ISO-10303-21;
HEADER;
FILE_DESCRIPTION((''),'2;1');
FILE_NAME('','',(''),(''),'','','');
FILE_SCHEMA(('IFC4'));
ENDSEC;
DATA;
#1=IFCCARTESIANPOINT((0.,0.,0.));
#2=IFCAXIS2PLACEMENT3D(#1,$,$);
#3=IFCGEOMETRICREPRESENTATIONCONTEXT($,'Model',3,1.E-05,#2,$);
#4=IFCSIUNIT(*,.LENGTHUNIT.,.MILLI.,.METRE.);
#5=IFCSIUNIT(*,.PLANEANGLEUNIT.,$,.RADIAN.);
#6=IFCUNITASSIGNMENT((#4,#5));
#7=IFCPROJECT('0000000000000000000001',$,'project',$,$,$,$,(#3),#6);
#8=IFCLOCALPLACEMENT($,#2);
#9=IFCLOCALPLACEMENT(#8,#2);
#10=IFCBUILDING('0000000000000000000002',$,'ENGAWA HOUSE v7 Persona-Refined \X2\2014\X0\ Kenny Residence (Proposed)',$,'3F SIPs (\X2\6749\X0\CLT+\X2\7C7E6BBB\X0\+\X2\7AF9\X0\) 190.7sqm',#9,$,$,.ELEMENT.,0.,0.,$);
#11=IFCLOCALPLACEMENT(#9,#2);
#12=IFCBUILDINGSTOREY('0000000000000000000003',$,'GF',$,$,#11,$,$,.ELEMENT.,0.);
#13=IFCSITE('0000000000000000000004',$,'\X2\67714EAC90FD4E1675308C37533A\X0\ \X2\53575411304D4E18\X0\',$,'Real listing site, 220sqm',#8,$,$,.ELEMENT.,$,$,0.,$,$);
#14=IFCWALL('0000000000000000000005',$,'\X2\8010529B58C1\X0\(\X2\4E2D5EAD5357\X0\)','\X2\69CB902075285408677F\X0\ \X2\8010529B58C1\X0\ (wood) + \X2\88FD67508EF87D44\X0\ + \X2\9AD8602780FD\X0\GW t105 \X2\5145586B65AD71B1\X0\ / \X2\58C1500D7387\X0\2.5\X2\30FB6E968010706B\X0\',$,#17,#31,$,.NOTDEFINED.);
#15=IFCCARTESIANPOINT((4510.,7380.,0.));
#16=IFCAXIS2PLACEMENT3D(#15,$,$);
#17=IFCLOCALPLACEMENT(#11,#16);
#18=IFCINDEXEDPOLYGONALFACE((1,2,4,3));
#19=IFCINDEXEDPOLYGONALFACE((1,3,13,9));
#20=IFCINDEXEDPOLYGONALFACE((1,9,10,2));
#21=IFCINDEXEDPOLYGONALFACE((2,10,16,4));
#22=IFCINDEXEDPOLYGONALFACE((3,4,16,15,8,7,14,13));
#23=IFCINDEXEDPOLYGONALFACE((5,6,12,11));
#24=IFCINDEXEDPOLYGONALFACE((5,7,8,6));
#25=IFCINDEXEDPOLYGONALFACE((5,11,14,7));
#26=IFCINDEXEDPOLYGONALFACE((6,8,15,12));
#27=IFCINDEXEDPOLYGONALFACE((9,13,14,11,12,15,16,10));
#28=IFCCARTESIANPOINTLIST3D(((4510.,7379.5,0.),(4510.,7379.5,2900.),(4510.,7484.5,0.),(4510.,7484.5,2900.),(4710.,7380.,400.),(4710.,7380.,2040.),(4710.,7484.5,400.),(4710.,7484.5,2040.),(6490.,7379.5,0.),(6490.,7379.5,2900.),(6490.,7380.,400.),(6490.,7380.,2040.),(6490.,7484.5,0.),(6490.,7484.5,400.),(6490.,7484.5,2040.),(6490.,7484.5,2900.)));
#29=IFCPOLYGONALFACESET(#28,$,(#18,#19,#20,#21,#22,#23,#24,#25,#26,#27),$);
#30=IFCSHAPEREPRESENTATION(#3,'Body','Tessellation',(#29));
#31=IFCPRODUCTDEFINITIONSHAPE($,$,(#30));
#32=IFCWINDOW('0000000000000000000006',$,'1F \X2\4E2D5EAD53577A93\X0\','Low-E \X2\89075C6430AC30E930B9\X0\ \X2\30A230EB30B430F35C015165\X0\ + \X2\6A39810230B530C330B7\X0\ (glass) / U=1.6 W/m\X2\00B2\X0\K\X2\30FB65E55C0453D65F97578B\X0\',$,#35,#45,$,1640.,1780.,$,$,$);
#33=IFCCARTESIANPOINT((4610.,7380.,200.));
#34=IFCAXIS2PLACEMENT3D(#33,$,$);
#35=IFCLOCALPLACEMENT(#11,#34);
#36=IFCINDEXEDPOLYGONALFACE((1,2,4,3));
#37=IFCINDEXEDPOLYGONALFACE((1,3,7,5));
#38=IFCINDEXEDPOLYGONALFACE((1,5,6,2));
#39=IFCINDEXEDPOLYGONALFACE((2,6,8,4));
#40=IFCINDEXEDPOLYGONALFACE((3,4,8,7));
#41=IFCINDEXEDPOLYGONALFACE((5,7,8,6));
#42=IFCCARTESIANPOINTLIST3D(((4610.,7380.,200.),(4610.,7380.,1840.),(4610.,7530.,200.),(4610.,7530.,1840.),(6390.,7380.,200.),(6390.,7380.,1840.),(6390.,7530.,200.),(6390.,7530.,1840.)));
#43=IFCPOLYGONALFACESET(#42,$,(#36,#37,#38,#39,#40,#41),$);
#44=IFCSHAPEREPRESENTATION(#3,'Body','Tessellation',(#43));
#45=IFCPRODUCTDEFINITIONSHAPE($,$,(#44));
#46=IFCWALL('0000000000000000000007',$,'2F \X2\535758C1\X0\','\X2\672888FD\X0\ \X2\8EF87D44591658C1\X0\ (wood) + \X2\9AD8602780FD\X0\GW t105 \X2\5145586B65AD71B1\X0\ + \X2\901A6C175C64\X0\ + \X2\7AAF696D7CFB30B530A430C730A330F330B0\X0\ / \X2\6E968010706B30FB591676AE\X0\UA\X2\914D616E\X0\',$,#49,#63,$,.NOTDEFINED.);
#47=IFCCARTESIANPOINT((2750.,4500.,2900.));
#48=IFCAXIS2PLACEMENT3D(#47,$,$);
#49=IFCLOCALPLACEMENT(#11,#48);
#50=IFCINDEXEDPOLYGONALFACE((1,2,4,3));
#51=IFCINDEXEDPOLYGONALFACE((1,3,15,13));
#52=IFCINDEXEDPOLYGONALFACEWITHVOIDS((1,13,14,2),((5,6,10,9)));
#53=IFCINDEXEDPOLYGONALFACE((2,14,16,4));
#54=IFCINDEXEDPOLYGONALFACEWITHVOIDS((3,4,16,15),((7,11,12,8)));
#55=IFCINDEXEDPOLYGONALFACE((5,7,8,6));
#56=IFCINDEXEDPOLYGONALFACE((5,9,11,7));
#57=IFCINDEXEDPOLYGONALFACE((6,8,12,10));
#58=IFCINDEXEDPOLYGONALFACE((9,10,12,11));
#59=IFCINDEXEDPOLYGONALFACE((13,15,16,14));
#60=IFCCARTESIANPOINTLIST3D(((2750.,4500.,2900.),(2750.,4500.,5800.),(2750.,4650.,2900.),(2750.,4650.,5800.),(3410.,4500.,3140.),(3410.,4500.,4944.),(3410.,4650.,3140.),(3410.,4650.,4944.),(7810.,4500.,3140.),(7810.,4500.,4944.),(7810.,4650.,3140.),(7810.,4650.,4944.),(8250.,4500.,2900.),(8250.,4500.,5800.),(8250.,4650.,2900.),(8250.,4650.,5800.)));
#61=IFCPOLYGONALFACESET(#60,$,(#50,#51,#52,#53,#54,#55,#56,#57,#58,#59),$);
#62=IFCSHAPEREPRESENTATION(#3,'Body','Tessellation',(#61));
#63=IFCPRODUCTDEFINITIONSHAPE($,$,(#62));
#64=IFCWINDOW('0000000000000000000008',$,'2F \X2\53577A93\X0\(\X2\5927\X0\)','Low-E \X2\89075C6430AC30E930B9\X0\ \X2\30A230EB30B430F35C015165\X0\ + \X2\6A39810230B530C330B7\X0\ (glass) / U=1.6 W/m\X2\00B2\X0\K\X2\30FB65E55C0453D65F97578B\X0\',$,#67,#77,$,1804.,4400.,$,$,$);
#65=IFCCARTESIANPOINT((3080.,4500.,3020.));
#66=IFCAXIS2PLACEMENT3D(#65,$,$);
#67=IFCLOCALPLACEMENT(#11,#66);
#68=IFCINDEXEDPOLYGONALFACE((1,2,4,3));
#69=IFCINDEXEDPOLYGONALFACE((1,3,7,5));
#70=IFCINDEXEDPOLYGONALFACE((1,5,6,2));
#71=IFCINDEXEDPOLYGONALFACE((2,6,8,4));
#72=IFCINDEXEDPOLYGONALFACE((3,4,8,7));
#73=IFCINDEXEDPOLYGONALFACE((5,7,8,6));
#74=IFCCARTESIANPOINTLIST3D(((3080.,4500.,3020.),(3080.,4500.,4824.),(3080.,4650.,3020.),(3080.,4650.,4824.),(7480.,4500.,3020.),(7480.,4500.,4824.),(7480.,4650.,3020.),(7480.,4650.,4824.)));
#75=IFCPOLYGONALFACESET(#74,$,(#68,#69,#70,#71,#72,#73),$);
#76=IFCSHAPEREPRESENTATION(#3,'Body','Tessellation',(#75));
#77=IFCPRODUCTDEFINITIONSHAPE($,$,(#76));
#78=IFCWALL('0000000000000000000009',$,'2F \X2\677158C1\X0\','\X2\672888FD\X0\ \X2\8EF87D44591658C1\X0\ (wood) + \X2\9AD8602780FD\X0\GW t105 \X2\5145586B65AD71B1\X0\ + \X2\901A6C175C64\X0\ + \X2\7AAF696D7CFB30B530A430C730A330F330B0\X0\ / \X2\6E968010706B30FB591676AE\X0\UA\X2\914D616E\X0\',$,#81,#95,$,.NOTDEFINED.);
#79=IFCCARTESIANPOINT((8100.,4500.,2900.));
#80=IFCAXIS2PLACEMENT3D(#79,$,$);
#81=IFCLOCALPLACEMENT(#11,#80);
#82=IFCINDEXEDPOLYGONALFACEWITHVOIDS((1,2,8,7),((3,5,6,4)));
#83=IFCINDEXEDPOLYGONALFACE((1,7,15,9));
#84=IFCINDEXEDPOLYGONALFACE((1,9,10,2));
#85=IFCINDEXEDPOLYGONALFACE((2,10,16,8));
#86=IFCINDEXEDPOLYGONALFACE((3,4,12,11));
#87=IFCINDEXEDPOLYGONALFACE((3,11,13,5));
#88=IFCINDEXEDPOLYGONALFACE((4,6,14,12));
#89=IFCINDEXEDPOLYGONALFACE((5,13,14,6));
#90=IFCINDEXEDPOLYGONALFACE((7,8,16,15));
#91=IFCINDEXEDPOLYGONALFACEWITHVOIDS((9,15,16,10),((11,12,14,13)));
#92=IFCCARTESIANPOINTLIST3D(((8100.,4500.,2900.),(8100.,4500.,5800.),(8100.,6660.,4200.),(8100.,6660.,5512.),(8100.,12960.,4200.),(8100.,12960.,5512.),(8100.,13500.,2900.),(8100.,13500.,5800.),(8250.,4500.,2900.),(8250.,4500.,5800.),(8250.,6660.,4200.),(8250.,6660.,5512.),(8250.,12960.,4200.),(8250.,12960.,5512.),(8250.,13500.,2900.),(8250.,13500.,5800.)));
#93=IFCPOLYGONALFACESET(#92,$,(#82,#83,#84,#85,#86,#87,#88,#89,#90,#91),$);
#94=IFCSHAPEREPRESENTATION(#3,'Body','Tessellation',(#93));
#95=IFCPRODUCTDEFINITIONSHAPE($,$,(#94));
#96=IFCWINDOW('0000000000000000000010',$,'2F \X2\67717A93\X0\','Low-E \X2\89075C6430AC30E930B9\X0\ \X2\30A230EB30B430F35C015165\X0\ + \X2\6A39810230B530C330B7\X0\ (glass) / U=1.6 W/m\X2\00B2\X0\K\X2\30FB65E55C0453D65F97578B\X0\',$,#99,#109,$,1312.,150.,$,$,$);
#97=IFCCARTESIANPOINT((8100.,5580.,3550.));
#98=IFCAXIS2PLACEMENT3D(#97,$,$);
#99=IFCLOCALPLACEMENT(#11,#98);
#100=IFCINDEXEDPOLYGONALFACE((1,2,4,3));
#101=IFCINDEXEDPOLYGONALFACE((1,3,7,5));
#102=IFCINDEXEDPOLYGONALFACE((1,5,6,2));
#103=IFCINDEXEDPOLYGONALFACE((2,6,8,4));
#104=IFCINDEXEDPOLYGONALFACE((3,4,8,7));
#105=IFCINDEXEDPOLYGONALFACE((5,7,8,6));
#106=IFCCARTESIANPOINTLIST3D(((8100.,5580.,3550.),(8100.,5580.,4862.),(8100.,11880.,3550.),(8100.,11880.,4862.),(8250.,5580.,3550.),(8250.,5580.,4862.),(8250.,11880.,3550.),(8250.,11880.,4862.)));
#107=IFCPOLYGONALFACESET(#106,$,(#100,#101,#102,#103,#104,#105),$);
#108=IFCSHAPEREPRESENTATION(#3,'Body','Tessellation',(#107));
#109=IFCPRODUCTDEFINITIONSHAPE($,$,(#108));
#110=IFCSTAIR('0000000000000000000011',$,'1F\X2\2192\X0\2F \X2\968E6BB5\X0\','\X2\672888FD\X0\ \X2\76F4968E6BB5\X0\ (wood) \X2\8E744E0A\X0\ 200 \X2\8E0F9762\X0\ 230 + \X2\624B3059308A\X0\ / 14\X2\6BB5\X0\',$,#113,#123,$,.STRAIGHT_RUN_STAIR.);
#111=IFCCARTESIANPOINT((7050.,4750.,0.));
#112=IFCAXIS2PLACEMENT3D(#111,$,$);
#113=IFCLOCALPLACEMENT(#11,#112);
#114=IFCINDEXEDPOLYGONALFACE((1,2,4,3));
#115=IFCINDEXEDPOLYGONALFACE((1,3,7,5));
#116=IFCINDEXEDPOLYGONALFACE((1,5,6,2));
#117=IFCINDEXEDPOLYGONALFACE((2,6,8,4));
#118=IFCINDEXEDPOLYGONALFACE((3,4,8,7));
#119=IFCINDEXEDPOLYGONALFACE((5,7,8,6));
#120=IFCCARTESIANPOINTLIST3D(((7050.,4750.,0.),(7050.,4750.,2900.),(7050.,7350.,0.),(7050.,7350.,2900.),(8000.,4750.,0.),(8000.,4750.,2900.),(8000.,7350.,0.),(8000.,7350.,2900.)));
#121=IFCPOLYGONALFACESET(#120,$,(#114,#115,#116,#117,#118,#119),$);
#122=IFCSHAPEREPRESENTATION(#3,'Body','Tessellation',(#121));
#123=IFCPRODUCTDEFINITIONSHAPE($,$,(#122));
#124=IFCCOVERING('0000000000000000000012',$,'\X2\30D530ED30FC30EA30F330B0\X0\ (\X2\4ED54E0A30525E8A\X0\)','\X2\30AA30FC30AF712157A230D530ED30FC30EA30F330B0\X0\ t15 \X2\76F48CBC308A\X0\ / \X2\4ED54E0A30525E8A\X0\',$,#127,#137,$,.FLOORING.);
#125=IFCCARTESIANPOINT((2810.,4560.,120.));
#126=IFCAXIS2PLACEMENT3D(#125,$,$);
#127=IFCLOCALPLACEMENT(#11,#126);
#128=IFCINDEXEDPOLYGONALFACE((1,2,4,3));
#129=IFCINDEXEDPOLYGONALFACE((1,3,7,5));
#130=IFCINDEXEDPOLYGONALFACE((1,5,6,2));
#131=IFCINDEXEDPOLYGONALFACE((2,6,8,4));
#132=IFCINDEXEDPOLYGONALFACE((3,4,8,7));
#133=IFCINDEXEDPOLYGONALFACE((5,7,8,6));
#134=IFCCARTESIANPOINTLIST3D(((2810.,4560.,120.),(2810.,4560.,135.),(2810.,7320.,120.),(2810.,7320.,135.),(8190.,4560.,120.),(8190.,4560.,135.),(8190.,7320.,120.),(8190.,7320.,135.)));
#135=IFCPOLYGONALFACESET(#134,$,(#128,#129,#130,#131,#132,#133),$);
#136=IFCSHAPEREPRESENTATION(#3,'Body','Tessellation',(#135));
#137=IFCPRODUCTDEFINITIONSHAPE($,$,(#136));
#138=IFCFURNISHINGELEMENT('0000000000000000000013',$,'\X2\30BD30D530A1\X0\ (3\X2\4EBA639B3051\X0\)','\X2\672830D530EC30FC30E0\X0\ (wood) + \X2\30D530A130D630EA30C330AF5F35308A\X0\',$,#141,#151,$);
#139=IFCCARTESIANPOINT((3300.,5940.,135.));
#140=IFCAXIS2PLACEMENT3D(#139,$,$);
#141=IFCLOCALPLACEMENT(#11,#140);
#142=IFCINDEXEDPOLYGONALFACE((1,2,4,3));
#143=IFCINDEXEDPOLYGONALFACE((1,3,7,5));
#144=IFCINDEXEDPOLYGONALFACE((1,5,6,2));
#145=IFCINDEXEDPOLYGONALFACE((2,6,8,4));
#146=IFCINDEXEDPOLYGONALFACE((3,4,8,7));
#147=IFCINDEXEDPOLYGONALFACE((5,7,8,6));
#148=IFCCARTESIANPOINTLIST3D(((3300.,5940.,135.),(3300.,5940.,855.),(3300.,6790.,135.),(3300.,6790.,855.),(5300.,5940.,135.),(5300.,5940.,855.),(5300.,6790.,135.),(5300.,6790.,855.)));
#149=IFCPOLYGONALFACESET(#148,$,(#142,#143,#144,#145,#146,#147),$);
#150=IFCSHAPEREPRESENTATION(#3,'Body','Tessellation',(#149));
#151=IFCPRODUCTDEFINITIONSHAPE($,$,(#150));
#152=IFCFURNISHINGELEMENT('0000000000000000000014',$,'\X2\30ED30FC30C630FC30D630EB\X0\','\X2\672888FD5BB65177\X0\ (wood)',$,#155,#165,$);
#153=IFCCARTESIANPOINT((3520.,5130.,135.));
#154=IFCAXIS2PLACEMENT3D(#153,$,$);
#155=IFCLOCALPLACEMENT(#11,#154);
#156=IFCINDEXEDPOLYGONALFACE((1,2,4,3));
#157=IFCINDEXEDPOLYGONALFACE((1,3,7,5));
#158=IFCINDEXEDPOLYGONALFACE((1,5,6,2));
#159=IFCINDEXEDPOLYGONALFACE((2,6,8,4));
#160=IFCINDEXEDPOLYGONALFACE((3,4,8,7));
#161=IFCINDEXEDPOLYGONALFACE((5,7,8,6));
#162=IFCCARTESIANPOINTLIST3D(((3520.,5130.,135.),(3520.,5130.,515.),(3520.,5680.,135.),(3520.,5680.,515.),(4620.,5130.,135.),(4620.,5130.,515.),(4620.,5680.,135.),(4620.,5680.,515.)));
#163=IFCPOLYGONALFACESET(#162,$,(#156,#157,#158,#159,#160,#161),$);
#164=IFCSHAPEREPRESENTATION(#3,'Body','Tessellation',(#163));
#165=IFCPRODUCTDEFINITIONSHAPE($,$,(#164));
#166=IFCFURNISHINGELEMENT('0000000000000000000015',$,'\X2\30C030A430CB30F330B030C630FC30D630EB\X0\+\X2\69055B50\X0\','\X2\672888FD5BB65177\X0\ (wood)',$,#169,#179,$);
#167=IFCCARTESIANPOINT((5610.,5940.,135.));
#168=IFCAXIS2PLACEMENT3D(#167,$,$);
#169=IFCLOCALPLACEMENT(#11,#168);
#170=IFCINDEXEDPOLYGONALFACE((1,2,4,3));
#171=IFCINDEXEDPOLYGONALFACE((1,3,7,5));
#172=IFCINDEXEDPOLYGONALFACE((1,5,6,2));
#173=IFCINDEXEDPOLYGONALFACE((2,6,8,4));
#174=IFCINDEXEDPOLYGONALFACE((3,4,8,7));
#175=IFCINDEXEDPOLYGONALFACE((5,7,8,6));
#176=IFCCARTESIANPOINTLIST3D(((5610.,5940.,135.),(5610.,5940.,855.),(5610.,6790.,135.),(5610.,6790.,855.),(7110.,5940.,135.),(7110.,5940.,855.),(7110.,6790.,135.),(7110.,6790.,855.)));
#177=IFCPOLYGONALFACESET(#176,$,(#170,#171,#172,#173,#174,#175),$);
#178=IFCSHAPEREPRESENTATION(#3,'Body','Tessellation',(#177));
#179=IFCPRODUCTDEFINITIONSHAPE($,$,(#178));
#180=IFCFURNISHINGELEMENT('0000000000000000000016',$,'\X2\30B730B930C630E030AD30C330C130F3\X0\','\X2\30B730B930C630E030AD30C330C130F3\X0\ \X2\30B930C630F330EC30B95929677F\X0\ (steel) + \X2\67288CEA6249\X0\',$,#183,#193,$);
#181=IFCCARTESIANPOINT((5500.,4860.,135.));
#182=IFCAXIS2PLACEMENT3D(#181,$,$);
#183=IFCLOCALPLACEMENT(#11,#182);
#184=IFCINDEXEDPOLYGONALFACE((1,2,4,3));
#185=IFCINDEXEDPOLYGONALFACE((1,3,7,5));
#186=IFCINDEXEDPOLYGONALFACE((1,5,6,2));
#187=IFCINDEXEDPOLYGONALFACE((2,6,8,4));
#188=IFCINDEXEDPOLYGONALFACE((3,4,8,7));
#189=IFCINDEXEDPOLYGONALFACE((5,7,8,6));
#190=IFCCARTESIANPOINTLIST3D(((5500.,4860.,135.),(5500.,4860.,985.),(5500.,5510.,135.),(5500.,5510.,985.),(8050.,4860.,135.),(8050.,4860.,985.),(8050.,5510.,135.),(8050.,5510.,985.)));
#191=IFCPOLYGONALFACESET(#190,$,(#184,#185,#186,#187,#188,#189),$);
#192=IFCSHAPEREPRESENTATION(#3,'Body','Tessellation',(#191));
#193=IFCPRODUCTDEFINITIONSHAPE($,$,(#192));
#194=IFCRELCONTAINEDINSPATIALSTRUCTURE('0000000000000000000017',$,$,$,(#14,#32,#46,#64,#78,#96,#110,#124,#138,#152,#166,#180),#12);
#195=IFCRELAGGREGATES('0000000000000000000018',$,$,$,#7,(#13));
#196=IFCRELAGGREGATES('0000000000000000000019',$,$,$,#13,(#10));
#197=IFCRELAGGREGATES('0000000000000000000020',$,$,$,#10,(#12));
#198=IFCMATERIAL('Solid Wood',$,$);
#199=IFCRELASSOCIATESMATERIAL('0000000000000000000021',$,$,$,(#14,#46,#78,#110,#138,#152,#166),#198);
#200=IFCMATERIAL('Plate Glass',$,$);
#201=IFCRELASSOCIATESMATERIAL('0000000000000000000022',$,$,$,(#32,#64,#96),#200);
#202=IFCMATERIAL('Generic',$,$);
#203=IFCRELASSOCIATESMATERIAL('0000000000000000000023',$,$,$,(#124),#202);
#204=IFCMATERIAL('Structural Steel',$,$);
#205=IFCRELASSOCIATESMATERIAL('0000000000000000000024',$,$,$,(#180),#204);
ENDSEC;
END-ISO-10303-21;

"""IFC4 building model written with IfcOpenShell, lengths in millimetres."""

from ifc_helpers import new_model, si_unit, frame, frame_2d, origin, place, context, project, spatial, rectangle, extrude, material, element, fill, save


model = new_model("IFC4")

# Units and contexts
model_context = context("Model", 3, precision=1e-05, world=origin())
ifc_project = project(units=[si_unit("LENGTHUNIT", "METRE", prefix="MILLI"), si_unit("PLANEANGLEUNIT", "RADIAN")], contexts=[model_context])

# Site, building, storey
site_placement = place(None, origin())
site = spatial("IfcSite", under=ifc_project, at=site_placement, Name="東京都世田谷区 南向き丘", ObjectType="Real listing site, 220sqm", CompositionType="ELEMENT", RefElevation=0.0)
building_placement = place(site_placement, origin())
building = spatial("IfcBuilding", under=site, at=building_placement, Name="ENGAWA HOUSE v7 Persona-Refined — Kenny Residence (Proposed)", ObjectType="3F SIPs (杉CLT+籾殻+竹) 190.7sqm", CompositionType="ELEMENT", ElevationOfRefHeight=0.0, ElevationOfTerrain=0.0)
storey_placement = place(building_placement, origin())
storey = spatial("IfcBuildingStorey", under=building, at=storey_placement, Name="GF", CompositionType="ELEMENT", Elevation=0.0)

# Shared definitions
ifc_material_1 = material(Name="Solid Wood")
ifc_material_2 = material(Name="Generic")

# Shared definitions
ifc_material_3 = material(Name="Plate Glass")

# Wall, opening, window
wall_1_placement = place(storey_placement, frame((4510.0, 7380.0, 0.0)))
wall_1 = element("IfcWall", 1, at=wall_1_placement, inside=storey, material=ifc_material_1, Name="耐力壁(中庭南)", Description="構造用合板 耐力壁 (wood) + 製材軸組 + 高性能GW t105 充填断熱 / 壁倍率2.5・準耐火", PredefinedType="NOTDEFINED", context=model_context, shape_type="SweptSolid", body=[
    extrude(rectangle(XDim=1980.0, YDim=105.0, at=frame_2d((990.0, 52.0))), frame((4510.0, 7380.0, 0.0)), (0.0, 0.0, 1.0), 2900.0),
])
opening_1_placement = place(storey_placement, frame((4610.0, 7380.0, 200.0)))
opening_1 = element("IfcOpeningElement", 2, at=opening_1_placement, cuts=wall_1, PredefinedType="NOTDEFINED", context=model_context, shape_type="SweptSolid", body=[
    extrude(rectangle(XDim=1780.0, YDim=150.0, at=frame_2d((890.0, 75.0))), frame((4610.0, 7380.0, 200.0)), (0.0, 0.0, 1.0), 1640.0),
])
window_1_placement = place(storey_placement, frame((4610.0, 7380.0, 200.0)))
window_1 = element("IfcWindow", 3, at=window_1_placement, inside=storey, material=ifc_material_3, Name="1F 中庭南窓", Description="Low-E 複層ガラス アルゴン封入 + 樹脂サッシ (glass) / U=1.6 W/m²K・日射取得型", OverallHeight=1640.0, OverallWidth=1780.0, context=model_context, shape_type="SweptSolid", body=[
    extrude(rectangle(XDim=1780.0, YDim=150.0, at=frame_2d((890.0, 75.0))), frame((4610.0, 7380.0, 200.0)), (0.0, 0.0, 1.0), 1640.0),
])
fill(opening_1, window_1)

# Walls, openings, windows
wall_2_placement = place(storey_placement, frame((2750.0, 4500.0, 2900.0)))
wall_2 = element("IfcWall", 4, at=wall_2_placement, inside=storey, material=ifc_material_1, Name="2F 南壁", Description="木製 軸組外壁 (wood) + 高性能GW t105 充填断熱 + 通気層 + 窯業系サイディング / 準耐火・外皮UA配慮", PredefinedType="NOTDEFINED", context=model_context, shape_type="SweptSolid", body=[
    extrude(rectangle(XDim=5500.0, YDim=150.0, at=frame_2d((2750.0, 75.0))), frame((2750.0, 4500.0, 2900.0)), (0.0, 0.0, 1.0), 2900.0),
])
opening_2_placement = place(storey_placement, frame((3080.0, 4500.0, 3020.0)))
opening_2 = element("IfcOpeningElement", 5, at=opening_2_placement, cuts=wall_2, PredefinedType="NOTDEFINED", context=model_context, shape_type="SweptSolid", body=[
    extrude(rectangle(XDim=4400.0, YDim=150.0, at=frame_2d((2200.0, 75.0))), frame((3080.0, 4500.0, 3020.0)), (0.0, 0.0, 1.0), 1804.0),
])
window_2_placement = place(storey_placement, frame((3080.0, 4500.0, 3020.0)))
window_2 = element("IfcWindow", 6, at=window_2_placement, inside=storey, material=ifc_material_3, Name="2F 南窓(大)", Description="Low-E 複層ガラス アルゴン封入 + 樹脂サッシ (glass) / U=1.6 W/m²K・日射取得型", OverallHeight=1804.0, OverallWidth=4400.0, context=model_context, shape_type="SweptSolid", body=[
    extrude(rectangle(XDim=4400.0, YDim=150.0, at=frame_2d((2200.0, 75.0))), frame((3080.0, 4500.0, 3020.0)), (0.0, 0.0, 1.0), 1804.0),
])
fill(opening_2, window_2)
wall_3_placement = place(storey_placement, frame((8100.0, 4500.0, 2900.0)))
wall_3 = element("IfcWall", 7, at=wall_3_placement, inside=storey, material=ifc_material_1, Name="2F 東壁", Description="木製 軸組外壁 (wood) + 高性能GW t105 充填断熱 + 通気層 + 窯業系サイディング / 準耐火・外皮UA配慮", PredefinedType="NOTDEFINED", context=model_context, shape_type="SweptSolid", body=[
    extrude(rectangle(XDim=150.0, YDim=9000.0, at=frame_2d((75.0, 4500.0))), frame((8100.0, 4500.0, 2900.0)), (0.0, 0.0, 1.0), 2900.0),
])
opening_3_placement = place(storey_placement, frame((8100.0, 5580.0, 3550.0)))
opening_3 = element("IfcOpeningElement", 8, at=opening_3_placement, cuts=wall_3, PredefinedType="NOTDEFINED", context=model_context, shape_type="SweptSolid", body=[
    extrude(rectangle(XDim=150.0, YDim=6300.0, at=frame_2d((75.0, 3150.0))), frame((8100.0, 5580.0, 3550.0)), (0.0, 0.0, 1.0), 1312.0),
])
window_3_placement = place(storey_placement, frame((8100.0, 5580.0, 3550.0)))
window_3 = element("IfcWindow", 9, at=window_3_placement, inside=storey, material=ifc_material_3, Name="2F 東窓", Description="Low-E 複層ガラス アルゴン封入 + 樹脂サッシ (glass) / U=1.6 W/m²K・日射取得型", OverallHeight=1312.0, OverallWidth=150.0, context=model_context, shape_type="SweptSolid", body=[
    extrude(rectangle(XDim=150.0, YDim=6300.0, at=frame_2d((75.0, 3150.0))), frame((8100.0, 5580.0, 3550.0)), (0.0, 0.0, 1.0), 1312.0),
])
fill(opening_3, window_3)

# Stair
stair_placement = place(storey_placement, frame((7050.0, 4750.0, 0.0)))
element("IfcStair", 10, at=stair_placement, inside=storey, material=ifc_material_1, Name="1F→2F 階段", Description="木製 直階段 (wood) 蹴上 200 踏面 230 + 手すり / 14段", PredefinedType="STRAIGHT_RUN_STAIR", context=model_context, shape_type="SweptSolid", body=[
    extrude(rectangle(XDim=950.0, YDim=2600.0, at=frame_2d((475.0, 1300.0))), frame((7050.0, 4750.0, 0.0)), (0.0, 0.0, 1.0), 2900.0),
])

# Covering
covering_placement = place(storey_placement, frame((2810.0, 4560.0, 120.0)))
element("IfcCovering", 11, at=covering_placement, inside=storey, material=ifc_material_2, Name="フローリング (仕上げ床)", Description="オーク無垢フローリング t15 直貼り / 仕上げ床", PredefinedType="FLOORING", context=model_context, shape_type="SweptSolid", body=[
    extrude(rectangle(XDim=5380.0, YDim=2760.0, at=frame_2d((2690.0, 1380.0))), frame((2810.0, 4560.0, 120.0)), (0.0, 0.0, 1.0), 15.0),
])

# Furnishing elements
furnishing_1_placement = place(storey_placement, frame((3300.0, 5940.0, 135.0)))
element("IfcFurnishingElement", 12, at=furnishing_1_placement, inside=storey, material=ifc_material_1, Name="ソファ (3人掛け)", Description="木フレーム (wood) + ファブリック張り", context=model_context, shape_type="SweptSolid", body=[
    extrude(rectangle(XDim=2000.0, YDim=850.0, at=frame_2d((1000.0, 425.0))), frame((3300.0, 5940.0, 135.0)), (0.0, 0.0, 1.0), 720.0),
])
furnishing_2_placement = place(storey_placement, frame((3520.0, 5130.0, 135.0)))
element("IfcFurnishingElement", 13, at=furnishing_2_placement, inside=storey, material=ifc_material_1, Name="ローテーブル", Description="木製家具 (wood)", context=model_context, shape_type="SweptSolid", body=[
    extrude(rectangle(XDim=1100.0, YDim=550.0, at=frame_2d((550.0, 275.0))), frame((3520.0, 5130.0, 135.0)), (0.0, 0.0, 1.0), 380.0),
])
furnishing_3_placement = place(storey_placement, frame((5610.0, 5940.0, 135.0)))
element("IfcFurnishingElement", 14, at=furnishing_3_placement, inside=storey, material=ifc_material_1, Name="ダイニングテーブル+椅子", Description="木製家具 (wood)", context=model_context, shape_type="SweptSolid", body=[
    extrude(rectangle(XDim=1500.0, YDim=850.0, at=frame_2d((750.0, 425.0))), frame((5610.0, 5940.0, 135.0)), (0.0, 0.0, 1.0), 720.0),
])
ifc_material_4 = material(Name="Structural Steel")
furnishing_4_placement = place(storey_placement, frame((5500.0, 4860.0, 135.0)))
element("IfcFurnishingElement", 15, at=furnishing_4_placement, inside=storey, material=ifc_material_4, Name="システムキッチン", Description="システムキッチン ステンレス天板 (steel) + 木質扉", context=model_context, shape_type="SweptSolid", body=[
    extrude(rectangle(XDim=2550.0, YDim=650.0, at=frame_2d((1275.0, 325.0))), frame((5500.0, 4860.0, 135.0)), (0.0, 0.0, 1.0), 850.0),
])

save(model, "model.ifc")
